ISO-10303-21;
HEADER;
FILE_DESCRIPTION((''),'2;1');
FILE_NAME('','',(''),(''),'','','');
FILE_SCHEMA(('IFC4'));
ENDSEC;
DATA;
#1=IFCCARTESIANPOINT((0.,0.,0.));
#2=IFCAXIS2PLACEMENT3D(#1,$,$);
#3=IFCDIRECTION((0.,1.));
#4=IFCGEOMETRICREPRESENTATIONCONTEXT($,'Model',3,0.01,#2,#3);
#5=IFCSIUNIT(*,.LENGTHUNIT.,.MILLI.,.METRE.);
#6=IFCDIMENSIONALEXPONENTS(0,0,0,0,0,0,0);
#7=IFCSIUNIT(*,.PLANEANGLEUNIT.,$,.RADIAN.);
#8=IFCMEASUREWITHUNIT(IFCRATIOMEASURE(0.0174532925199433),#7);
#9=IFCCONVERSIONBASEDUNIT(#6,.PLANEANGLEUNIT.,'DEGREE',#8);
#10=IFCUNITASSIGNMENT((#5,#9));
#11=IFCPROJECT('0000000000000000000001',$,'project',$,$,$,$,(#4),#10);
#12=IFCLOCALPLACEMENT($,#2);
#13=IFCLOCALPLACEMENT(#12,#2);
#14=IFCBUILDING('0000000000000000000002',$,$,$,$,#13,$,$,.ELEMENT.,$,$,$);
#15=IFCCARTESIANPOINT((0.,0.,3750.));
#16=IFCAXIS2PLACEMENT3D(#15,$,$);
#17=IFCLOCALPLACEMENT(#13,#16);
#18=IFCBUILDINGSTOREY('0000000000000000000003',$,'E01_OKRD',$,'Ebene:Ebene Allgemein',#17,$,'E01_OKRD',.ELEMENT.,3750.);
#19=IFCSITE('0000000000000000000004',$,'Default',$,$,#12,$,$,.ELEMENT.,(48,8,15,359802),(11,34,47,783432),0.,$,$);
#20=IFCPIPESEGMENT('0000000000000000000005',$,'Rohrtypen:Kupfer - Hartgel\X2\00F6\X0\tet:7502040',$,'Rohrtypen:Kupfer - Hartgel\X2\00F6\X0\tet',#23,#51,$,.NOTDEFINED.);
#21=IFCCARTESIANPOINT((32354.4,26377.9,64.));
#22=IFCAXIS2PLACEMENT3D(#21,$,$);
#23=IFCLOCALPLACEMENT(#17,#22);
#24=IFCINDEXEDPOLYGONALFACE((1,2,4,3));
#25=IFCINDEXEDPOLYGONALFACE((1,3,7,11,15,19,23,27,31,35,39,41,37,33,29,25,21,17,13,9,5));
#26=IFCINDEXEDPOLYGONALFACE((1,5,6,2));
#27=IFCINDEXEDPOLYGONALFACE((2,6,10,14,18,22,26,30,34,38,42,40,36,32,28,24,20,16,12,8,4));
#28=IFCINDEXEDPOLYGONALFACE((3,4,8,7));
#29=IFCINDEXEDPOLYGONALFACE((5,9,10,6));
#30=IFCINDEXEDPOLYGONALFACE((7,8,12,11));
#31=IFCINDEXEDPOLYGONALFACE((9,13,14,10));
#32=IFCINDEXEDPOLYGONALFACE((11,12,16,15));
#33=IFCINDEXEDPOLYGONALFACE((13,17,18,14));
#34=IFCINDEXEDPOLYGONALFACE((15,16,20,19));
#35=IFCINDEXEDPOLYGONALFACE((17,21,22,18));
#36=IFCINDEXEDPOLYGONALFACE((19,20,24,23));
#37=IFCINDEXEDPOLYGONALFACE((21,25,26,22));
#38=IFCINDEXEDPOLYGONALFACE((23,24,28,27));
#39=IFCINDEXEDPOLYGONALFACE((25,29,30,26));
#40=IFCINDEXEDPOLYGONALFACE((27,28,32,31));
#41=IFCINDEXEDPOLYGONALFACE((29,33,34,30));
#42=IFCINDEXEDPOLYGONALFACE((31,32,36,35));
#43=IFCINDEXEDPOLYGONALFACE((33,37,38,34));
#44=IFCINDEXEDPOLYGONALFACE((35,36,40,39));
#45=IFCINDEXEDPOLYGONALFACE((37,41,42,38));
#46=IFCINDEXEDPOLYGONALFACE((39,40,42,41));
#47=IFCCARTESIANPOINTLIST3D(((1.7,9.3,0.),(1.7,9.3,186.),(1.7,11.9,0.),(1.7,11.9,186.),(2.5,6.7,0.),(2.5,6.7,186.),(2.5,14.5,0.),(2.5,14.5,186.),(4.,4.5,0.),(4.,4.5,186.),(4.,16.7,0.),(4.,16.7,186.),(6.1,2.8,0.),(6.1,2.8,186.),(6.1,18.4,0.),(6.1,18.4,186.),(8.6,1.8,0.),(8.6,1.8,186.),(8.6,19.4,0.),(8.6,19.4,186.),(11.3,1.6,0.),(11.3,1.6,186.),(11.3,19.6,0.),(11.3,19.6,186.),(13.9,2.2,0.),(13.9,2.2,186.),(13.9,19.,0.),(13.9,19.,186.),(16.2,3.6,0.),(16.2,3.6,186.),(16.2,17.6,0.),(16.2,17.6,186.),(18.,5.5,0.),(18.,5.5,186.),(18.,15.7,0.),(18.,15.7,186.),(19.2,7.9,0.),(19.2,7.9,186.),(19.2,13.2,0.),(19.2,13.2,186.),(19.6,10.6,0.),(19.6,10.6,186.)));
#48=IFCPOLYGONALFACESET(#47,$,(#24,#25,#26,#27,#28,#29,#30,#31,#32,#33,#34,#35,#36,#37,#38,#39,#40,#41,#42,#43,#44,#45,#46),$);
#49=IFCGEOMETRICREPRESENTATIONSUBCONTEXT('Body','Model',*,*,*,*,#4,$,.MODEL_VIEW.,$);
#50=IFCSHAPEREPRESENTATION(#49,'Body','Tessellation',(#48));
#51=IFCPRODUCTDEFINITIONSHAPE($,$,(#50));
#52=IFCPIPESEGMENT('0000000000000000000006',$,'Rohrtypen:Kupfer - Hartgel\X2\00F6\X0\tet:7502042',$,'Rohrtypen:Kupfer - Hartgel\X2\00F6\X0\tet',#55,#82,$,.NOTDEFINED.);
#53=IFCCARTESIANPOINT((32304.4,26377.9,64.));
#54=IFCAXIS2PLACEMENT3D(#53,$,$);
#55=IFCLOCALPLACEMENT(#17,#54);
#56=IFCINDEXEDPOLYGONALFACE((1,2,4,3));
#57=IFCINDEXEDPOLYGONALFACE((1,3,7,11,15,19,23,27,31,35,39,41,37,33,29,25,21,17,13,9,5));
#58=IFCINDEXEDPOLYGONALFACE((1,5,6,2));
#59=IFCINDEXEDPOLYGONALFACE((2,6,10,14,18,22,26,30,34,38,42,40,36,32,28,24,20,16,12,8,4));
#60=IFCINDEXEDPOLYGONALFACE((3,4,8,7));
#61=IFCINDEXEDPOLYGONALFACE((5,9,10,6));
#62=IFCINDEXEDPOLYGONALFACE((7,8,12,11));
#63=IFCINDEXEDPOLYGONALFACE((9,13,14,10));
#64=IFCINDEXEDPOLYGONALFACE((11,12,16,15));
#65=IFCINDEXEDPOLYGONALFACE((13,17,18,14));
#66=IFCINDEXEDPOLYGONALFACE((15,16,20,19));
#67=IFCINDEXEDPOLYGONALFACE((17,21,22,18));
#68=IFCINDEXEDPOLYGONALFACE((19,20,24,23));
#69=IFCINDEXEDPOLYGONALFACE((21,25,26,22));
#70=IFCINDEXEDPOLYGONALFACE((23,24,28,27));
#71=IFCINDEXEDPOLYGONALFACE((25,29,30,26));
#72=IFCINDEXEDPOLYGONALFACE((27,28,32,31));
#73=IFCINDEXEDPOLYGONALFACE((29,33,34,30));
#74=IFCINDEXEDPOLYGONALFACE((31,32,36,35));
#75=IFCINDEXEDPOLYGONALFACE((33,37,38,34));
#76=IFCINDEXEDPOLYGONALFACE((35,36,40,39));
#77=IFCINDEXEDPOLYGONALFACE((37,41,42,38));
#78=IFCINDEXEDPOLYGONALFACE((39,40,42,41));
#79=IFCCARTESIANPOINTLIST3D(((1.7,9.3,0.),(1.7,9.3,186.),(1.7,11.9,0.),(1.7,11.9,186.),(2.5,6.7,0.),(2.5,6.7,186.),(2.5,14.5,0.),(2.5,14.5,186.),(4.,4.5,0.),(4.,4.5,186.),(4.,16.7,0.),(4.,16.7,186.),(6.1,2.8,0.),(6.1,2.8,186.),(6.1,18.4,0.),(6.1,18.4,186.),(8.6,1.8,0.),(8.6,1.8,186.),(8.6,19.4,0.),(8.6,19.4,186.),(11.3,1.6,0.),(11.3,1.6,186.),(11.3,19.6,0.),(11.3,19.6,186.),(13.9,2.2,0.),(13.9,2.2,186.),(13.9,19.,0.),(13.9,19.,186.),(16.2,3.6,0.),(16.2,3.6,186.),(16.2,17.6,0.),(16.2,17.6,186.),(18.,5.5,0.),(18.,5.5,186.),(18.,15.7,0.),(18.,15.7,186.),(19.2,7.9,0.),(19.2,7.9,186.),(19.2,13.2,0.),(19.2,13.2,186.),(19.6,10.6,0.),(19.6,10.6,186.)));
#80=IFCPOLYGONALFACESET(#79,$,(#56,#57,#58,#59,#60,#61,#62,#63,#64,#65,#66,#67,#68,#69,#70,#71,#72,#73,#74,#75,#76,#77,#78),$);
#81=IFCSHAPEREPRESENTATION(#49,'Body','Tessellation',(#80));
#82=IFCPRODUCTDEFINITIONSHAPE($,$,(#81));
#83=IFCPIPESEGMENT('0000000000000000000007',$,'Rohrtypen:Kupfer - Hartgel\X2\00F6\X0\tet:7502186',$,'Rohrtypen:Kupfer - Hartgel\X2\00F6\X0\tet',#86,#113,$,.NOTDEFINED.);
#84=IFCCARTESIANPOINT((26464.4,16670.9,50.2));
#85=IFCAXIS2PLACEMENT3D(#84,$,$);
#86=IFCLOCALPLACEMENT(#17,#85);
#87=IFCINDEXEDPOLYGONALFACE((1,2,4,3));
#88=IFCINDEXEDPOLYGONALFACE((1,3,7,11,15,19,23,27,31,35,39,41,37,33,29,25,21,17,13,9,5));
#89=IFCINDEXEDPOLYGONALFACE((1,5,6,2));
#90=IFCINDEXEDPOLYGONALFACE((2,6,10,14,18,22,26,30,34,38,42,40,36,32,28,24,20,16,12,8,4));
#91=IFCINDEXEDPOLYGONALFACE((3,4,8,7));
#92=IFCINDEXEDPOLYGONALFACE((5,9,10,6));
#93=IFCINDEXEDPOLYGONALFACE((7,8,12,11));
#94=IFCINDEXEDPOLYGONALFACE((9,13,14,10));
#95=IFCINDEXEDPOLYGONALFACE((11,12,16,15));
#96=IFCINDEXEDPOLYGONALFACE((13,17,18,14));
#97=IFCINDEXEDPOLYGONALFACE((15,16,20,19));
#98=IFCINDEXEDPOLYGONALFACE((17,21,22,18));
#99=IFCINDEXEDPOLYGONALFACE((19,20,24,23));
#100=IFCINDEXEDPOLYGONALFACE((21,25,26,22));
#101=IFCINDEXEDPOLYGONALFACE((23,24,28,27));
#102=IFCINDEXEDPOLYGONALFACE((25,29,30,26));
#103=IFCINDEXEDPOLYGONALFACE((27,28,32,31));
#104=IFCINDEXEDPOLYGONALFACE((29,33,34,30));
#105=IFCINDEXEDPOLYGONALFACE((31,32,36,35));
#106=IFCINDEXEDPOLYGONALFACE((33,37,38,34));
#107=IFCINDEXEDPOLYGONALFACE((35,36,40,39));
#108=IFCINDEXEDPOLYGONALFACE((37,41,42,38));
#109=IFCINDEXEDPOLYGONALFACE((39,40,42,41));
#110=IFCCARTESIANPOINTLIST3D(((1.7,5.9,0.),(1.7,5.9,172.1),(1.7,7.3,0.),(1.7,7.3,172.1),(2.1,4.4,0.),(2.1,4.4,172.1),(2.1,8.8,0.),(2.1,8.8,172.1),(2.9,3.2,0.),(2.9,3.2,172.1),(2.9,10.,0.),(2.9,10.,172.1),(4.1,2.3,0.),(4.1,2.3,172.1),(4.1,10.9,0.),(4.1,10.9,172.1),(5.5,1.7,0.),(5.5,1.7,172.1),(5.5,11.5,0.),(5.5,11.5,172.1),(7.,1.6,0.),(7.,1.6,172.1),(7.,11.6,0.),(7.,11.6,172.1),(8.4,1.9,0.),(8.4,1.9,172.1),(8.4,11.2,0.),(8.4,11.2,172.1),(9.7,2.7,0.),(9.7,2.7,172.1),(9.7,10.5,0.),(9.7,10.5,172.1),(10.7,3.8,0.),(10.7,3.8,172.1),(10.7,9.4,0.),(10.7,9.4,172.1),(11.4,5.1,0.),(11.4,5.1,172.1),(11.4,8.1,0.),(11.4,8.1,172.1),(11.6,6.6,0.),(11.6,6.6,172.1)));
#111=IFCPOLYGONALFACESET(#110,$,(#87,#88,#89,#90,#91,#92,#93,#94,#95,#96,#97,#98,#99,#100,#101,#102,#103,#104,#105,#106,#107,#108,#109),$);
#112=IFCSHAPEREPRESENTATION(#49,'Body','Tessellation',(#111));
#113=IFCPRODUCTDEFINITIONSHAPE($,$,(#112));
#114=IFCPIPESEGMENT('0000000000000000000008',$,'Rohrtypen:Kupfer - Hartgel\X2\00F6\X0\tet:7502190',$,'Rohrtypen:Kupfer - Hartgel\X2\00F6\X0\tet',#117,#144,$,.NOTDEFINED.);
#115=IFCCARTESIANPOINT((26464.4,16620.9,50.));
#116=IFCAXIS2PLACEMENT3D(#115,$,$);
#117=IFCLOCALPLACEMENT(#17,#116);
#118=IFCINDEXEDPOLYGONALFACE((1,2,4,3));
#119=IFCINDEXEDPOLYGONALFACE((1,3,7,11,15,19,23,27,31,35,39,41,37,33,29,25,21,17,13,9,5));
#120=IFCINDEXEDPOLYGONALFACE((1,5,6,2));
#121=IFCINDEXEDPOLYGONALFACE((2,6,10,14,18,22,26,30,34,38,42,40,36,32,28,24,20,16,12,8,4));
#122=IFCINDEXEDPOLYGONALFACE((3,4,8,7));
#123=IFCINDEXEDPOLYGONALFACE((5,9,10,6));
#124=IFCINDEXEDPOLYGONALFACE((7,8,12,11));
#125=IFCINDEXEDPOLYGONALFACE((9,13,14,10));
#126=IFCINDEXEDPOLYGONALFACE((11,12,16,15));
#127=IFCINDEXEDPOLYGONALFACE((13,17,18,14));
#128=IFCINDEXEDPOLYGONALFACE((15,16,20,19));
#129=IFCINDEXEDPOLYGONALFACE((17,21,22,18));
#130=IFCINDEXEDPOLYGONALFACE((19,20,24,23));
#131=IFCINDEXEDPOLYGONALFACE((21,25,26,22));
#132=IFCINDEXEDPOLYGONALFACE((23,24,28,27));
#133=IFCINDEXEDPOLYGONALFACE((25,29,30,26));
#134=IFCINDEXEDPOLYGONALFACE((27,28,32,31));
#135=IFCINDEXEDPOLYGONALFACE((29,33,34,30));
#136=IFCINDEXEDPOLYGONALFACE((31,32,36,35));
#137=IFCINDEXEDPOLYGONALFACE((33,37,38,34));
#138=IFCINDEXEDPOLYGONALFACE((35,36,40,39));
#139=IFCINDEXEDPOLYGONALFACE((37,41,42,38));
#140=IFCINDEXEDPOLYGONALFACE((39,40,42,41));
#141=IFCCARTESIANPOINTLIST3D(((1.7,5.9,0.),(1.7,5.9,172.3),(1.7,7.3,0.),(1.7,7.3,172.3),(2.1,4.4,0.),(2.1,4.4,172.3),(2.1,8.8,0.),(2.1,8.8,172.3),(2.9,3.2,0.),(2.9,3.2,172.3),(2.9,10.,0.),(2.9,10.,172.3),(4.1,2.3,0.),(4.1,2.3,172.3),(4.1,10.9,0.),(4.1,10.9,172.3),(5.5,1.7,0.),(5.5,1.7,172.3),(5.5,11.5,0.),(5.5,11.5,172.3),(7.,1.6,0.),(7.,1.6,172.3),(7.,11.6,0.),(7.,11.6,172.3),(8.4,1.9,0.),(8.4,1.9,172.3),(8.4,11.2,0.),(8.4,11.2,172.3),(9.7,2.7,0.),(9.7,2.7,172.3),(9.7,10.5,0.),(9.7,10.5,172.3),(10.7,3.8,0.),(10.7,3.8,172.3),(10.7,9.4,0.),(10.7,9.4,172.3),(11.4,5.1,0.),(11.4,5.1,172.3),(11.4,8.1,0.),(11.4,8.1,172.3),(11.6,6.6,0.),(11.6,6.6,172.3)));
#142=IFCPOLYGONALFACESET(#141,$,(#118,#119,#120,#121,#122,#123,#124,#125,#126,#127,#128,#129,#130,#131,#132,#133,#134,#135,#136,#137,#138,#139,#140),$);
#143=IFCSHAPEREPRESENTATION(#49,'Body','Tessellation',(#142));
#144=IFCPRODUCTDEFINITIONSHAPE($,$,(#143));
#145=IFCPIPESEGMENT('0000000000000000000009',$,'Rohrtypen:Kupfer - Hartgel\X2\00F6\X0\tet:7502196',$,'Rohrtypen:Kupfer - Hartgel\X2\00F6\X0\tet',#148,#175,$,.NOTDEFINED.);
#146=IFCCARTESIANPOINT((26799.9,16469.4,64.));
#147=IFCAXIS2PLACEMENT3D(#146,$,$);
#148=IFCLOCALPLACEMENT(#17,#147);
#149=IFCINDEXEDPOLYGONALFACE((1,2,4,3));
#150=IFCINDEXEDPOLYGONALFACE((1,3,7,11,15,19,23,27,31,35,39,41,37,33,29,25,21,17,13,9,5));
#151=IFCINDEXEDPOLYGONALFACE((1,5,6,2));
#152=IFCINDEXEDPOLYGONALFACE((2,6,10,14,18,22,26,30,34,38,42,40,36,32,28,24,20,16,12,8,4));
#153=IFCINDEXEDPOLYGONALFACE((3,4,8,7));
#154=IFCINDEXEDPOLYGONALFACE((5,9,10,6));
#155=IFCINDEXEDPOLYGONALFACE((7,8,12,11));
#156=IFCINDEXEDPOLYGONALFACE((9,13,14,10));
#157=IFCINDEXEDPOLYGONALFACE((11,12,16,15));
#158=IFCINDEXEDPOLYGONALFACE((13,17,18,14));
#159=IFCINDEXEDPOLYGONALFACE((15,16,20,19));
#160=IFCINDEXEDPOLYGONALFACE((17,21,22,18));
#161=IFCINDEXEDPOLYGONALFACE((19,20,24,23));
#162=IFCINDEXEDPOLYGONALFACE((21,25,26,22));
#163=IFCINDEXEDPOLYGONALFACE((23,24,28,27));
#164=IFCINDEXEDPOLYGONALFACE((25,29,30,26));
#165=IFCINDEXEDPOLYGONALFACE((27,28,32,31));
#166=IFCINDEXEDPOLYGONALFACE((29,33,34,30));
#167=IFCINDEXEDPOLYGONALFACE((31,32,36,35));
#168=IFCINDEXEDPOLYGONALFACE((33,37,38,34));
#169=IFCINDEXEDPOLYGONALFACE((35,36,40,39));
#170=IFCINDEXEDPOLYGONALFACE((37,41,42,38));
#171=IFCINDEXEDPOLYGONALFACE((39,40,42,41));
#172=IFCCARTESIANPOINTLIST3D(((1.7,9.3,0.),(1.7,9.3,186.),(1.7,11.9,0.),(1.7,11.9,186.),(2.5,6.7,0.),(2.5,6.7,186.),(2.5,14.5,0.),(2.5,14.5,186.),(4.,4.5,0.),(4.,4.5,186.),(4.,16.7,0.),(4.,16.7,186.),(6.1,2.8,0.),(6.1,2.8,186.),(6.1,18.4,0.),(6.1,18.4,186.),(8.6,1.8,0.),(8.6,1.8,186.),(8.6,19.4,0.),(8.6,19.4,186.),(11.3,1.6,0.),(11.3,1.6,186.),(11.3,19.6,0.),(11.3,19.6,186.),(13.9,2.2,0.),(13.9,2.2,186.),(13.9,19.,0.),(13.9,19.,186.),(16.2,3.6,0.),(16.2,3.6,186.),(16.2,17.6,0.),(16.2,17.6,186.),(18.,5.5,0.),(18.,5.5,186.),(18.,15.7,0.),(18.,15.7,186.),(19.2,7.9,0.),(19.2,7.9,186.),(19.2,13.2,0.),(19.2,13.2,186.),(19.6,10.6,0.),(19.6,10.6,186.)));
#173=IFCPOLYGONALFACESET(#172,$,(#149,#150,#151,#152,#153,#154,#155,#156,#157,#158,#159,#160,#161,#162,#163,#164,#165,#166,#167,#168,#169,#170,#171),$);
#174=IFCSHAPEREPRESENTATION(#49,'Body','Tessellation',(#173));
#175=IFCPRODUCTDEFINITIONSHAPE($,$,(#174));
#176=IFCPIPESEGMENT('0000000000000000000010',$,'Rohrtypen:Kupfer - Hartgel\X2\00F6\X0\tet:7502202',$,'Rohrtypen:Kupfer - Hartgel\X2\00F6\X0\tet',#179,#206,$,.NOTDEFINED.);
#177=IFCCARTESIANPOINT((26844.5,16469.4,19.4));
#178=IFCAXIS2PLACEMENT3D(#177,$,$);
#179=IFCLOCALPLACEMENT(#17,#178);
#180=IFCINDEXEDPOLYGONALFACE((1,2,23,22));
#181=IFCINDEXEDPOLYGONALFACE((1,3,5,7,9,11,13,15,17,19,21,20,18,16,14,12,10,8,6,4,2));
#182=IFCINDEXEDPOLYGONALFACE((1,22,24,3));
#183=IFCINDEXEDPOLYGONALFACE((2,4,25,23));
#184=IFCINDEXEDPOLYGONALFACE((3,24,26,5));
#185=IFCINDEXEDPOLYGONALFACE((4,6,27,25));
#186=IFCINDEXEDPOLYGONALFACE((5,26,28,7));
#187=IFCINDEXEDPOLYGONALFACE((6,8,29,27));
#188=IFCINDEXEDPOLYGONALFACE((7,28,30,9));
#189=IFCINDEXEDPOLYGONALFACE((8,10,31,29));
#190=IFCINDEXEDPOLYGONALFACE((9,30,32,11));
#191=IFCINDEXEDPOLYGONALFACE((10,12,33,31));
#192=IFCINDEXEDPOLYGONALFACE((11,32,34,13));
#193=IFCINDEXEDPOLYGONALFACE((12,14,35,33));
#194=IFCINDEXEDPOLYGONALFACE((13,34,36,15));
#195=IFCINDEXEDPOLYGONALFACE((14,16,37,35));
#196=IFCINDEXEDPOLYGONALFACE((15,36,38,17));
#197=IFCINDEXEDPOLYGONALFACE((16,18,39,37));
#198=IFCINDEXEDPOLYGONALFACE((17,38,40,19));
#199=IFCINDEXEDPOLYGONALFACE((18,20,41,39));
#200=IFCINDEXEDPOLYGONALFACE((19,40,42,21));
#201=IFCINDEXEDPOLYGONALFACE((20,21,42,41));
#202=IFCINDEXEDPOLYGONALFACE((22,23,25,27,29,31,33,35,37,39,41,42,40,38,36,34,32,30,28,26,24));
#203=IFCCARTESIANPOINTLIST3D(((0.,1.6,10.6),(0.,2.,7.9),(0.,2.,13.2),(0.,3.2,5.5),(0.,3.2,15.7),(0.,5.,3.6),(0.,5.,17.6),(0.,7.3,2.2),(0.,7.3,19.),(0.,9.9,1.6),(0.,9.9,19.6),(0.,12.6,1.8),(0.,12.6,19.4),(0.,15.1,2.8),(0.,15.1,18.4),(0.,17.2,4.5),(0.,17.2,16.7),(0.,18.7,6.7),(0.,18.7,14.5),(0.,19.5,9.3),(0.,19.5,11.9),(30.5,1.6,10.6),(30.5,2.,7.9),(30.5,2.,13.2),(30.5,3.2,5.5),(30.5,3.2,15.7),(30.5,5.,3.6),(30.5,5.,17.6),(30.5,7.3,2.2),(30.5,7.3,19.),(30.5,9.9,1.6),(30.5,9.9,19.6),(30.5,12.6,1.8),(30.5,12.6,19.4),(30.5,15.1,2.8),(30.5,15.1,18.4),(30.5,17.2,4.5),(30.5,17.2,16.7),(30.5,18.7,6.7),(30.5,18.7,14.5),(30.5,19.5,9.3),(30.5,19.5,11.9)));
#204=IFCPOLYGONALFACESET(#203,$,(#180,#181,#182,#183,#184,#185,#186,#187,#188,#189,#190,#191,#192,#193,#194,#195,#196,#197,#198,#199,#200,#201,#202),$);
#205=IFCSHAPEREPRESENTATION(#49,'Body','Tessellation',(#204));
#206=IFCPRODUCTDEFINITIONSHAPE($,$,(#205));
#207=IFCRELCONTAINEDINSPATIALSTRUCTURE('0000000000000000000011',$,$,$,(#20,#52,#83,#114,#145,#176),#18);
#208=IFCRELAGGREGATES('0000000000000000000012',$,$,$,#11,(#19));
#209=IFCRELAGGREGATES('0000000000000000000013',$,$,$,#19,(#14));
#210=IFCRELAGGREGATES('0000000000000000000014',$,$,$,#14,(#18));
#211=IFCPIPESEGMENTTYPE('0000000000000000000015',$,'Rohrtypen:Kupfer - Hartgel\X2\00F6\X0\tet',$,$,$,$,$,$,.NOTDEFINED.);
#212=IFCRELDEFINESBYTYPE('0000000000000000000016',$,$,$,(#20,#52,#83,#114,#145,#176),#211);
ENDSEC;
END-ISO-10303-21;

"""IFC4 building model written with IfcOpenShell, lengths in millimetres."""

from ifc_helpers import new_model, entity, si_unit, converted_unit, direction, frame, frame_2d, origin, origin_2d_with_axis, place, context, subcontext, project, spatial, circle, extrude, type_object, element, save


model = new_model("IFC4")

# Units and contexts
model_context = context("Model", 3, precision=0.01, world=origin(), true_north=direction((0.0, 1.0)))
body_context = subcontext(model_context, "Body", "Model", "MODEL_VIEW")
ifc_project = project(units=[si_unit("LENGTHUNIT", "METRE", prefix="MILLI"), converted_unit("PLANEANGLEUNIT", "DEGREE", entity("IfcRatioMeasure", 0.0174532925199433), si_unit("PLANEANGLEUNIT", "RADIAN"), dimensions=[0, 0, 0, 0, 0, 0, 0])], contexts=[model_context])

# Site, building, storey
site_placement = place(None, origin())
site = spatial("IfcSite", under=ifc_project, at=site_placement, Name="Default", CompositionType="ELEMENT", RefLatitude=(48, 8, 15, 359802), RefLongitude=(11, 34, 47, 783432), RefElevation=0.0)
building_placement = place(site_placement, origin())
building = spatial("IfcBuilding", under=site, at=building_placement, CompositionType="ELEMENT")
storey_placement = place(building_placement, frame((0.0, 0.0, 3750.0)))
storey = spatial("IfcBuildingStorey", under=building, at=storey_placement, Name="E01_OKRD", ObjectType="Ebene:Ebene Allgemein", LongName="E01_OKRD", CompositionType="ELEMENT", Elevation=3750.0)

# Pipe segments
pipe_segment_type = type_object("IfcPipeSegmentType", Name="Rohrtypen:Kupfer - Hartgelötet", PredefinedType="NOTDEFINED")
pipe_segment_1_placement = place(storey_placement, frame((32354.4, 26377.9, 64.0)))
element("IfcPipeSegment", 1, at=pipe_segment_1_placement, inside=storey, type_object=pipe_segment_type, Name="Rohrtypen:Kupfer - Hartgelötet:7502040", ObjectType="Rohrtypen:Kupfer - Hartgelötet", PredefinedType="NOTDEFINED", context=body_context, shape_type="SweptSolid", body=[
    extrude(circle(Radius=9.0, at=origin_2d_with_axis()), frame((10.6, 10.6, 0.0)), (0.0, 0.0, 1.0), 186.0),
])
pipe_segment_2_placement = place(storey_placement, frame((32304.4, 26377.9, 64.0)))
element("IfcPipeSegment", 2, at=pipe_segment_2_placement, inside=storey, type_object=pipe_segment_type, Name="Rohrtypen:Kupfer - Hartgelötet:7502042", ObjectType="Rohrtypen:Kupfer - Hartgelötet", PredefinedType="NOTDEFINED", context=body_context, shape_type="SweptSolid", body=[
    extrude(circle(Radius=9.0, at=origin_2d_with_axis()), frame((10.6, 10.6, 0.0)), (0.0, 0.0, 1.0), 186.0),
])
pipe_segment_3_placement = place(storey_placement, frame((26464.4, 16670.9, 50.2)))
element("IfcPipeSegment", 3, at=pipe_segment_3_placement, inside=storey, type_object=pipe_segment_type, Name="Rohrtypen:Kupfer - Hartgelötet:7502186", ObjectType="Rohrtypen:Kupfer - Hartgelötet", PredefinedType="NOTDEFINED", context=body_context, shape_type="SweptSolid", body=[
    extrude(circle(Radius=5.0, at=origin_2d_with_axis()), frame((6.6, 6.6, 0.0)), (0.0, 0.0, 1.0), 172.1),
])
pipe_segment_4_placement = place(storey_placement, frame((26464.4, 16620.9, 50.0)))
element("IfcPipeSegment", 4, at=pipe_segment_4_placement, inside=storey, type_object=pipe_segment_type, Name="Rohrtypen:Kupfer - Hartgelötet:7502190", ObjectType="Rohrtypen:Kupfer - Hartgelötet", PredefinedType="NOTDEFINED", context=body_context, shape_type="SweptSolid", body=[
    extrude(circle(Radius=5.0, at=frame_2d((0.0, 0.0), x_axis=(1.0, 0.0))), frame((6.6, 6.6, 0.0)), (0.0, 0.0, 1.0), 172.3),
])
pipe_segment_5_placement = place(storey_placement, frame((26799.9, 16469.4, 64.0)))
element("IfcPipeSegment", 5, at=pipe_segment_5_placement, inside=storey, type_object=pipe_segment_type, Name="Rohrtypen:Kupfer - Hartgelötet:7502196", ObjectType="Rohrtypen:Kupfer - Hartgelötet", PredefinedType="NOTDEFINED", context=body_context, shape_type="SweptSolid", body=[
    extrude(circle(Radius=9.0, at=frame_2d((0.0, 0.0), x_axis=(1.0, 0.0))), frame((10.6, 10.6, 0.0)), (0.0, 0.0, 1.0), 186.0),
])
pipe_segment_6_placement = place(storey_placement, frame((26844.5, 16469.4, 19.4)))
element("IfcPipeSegment", 6, at=pipe_segment_6_placement, inside=storey, type_object=pipe_segment_type, Name="Rohrtypen:Kupfer - Hartgelötet:7502202", ObjectType="Rohrtypen:Kupfer - Hartgelötet", PredefinedType="NOTDEFINED", context=body_context, shape_type="SweptSolid", body=[
    extrude(circle(Radius=9.0, at=origin_2d_with_axis()), frame((0.0, 10.6, 10.6), z_axis=(1.0, 0.0, 0.0), x_axis=(0.0, -1.0, 0.0)), (0.0, 0.0, 1.0), 30.5),
])

save(model, "model.ifc")
